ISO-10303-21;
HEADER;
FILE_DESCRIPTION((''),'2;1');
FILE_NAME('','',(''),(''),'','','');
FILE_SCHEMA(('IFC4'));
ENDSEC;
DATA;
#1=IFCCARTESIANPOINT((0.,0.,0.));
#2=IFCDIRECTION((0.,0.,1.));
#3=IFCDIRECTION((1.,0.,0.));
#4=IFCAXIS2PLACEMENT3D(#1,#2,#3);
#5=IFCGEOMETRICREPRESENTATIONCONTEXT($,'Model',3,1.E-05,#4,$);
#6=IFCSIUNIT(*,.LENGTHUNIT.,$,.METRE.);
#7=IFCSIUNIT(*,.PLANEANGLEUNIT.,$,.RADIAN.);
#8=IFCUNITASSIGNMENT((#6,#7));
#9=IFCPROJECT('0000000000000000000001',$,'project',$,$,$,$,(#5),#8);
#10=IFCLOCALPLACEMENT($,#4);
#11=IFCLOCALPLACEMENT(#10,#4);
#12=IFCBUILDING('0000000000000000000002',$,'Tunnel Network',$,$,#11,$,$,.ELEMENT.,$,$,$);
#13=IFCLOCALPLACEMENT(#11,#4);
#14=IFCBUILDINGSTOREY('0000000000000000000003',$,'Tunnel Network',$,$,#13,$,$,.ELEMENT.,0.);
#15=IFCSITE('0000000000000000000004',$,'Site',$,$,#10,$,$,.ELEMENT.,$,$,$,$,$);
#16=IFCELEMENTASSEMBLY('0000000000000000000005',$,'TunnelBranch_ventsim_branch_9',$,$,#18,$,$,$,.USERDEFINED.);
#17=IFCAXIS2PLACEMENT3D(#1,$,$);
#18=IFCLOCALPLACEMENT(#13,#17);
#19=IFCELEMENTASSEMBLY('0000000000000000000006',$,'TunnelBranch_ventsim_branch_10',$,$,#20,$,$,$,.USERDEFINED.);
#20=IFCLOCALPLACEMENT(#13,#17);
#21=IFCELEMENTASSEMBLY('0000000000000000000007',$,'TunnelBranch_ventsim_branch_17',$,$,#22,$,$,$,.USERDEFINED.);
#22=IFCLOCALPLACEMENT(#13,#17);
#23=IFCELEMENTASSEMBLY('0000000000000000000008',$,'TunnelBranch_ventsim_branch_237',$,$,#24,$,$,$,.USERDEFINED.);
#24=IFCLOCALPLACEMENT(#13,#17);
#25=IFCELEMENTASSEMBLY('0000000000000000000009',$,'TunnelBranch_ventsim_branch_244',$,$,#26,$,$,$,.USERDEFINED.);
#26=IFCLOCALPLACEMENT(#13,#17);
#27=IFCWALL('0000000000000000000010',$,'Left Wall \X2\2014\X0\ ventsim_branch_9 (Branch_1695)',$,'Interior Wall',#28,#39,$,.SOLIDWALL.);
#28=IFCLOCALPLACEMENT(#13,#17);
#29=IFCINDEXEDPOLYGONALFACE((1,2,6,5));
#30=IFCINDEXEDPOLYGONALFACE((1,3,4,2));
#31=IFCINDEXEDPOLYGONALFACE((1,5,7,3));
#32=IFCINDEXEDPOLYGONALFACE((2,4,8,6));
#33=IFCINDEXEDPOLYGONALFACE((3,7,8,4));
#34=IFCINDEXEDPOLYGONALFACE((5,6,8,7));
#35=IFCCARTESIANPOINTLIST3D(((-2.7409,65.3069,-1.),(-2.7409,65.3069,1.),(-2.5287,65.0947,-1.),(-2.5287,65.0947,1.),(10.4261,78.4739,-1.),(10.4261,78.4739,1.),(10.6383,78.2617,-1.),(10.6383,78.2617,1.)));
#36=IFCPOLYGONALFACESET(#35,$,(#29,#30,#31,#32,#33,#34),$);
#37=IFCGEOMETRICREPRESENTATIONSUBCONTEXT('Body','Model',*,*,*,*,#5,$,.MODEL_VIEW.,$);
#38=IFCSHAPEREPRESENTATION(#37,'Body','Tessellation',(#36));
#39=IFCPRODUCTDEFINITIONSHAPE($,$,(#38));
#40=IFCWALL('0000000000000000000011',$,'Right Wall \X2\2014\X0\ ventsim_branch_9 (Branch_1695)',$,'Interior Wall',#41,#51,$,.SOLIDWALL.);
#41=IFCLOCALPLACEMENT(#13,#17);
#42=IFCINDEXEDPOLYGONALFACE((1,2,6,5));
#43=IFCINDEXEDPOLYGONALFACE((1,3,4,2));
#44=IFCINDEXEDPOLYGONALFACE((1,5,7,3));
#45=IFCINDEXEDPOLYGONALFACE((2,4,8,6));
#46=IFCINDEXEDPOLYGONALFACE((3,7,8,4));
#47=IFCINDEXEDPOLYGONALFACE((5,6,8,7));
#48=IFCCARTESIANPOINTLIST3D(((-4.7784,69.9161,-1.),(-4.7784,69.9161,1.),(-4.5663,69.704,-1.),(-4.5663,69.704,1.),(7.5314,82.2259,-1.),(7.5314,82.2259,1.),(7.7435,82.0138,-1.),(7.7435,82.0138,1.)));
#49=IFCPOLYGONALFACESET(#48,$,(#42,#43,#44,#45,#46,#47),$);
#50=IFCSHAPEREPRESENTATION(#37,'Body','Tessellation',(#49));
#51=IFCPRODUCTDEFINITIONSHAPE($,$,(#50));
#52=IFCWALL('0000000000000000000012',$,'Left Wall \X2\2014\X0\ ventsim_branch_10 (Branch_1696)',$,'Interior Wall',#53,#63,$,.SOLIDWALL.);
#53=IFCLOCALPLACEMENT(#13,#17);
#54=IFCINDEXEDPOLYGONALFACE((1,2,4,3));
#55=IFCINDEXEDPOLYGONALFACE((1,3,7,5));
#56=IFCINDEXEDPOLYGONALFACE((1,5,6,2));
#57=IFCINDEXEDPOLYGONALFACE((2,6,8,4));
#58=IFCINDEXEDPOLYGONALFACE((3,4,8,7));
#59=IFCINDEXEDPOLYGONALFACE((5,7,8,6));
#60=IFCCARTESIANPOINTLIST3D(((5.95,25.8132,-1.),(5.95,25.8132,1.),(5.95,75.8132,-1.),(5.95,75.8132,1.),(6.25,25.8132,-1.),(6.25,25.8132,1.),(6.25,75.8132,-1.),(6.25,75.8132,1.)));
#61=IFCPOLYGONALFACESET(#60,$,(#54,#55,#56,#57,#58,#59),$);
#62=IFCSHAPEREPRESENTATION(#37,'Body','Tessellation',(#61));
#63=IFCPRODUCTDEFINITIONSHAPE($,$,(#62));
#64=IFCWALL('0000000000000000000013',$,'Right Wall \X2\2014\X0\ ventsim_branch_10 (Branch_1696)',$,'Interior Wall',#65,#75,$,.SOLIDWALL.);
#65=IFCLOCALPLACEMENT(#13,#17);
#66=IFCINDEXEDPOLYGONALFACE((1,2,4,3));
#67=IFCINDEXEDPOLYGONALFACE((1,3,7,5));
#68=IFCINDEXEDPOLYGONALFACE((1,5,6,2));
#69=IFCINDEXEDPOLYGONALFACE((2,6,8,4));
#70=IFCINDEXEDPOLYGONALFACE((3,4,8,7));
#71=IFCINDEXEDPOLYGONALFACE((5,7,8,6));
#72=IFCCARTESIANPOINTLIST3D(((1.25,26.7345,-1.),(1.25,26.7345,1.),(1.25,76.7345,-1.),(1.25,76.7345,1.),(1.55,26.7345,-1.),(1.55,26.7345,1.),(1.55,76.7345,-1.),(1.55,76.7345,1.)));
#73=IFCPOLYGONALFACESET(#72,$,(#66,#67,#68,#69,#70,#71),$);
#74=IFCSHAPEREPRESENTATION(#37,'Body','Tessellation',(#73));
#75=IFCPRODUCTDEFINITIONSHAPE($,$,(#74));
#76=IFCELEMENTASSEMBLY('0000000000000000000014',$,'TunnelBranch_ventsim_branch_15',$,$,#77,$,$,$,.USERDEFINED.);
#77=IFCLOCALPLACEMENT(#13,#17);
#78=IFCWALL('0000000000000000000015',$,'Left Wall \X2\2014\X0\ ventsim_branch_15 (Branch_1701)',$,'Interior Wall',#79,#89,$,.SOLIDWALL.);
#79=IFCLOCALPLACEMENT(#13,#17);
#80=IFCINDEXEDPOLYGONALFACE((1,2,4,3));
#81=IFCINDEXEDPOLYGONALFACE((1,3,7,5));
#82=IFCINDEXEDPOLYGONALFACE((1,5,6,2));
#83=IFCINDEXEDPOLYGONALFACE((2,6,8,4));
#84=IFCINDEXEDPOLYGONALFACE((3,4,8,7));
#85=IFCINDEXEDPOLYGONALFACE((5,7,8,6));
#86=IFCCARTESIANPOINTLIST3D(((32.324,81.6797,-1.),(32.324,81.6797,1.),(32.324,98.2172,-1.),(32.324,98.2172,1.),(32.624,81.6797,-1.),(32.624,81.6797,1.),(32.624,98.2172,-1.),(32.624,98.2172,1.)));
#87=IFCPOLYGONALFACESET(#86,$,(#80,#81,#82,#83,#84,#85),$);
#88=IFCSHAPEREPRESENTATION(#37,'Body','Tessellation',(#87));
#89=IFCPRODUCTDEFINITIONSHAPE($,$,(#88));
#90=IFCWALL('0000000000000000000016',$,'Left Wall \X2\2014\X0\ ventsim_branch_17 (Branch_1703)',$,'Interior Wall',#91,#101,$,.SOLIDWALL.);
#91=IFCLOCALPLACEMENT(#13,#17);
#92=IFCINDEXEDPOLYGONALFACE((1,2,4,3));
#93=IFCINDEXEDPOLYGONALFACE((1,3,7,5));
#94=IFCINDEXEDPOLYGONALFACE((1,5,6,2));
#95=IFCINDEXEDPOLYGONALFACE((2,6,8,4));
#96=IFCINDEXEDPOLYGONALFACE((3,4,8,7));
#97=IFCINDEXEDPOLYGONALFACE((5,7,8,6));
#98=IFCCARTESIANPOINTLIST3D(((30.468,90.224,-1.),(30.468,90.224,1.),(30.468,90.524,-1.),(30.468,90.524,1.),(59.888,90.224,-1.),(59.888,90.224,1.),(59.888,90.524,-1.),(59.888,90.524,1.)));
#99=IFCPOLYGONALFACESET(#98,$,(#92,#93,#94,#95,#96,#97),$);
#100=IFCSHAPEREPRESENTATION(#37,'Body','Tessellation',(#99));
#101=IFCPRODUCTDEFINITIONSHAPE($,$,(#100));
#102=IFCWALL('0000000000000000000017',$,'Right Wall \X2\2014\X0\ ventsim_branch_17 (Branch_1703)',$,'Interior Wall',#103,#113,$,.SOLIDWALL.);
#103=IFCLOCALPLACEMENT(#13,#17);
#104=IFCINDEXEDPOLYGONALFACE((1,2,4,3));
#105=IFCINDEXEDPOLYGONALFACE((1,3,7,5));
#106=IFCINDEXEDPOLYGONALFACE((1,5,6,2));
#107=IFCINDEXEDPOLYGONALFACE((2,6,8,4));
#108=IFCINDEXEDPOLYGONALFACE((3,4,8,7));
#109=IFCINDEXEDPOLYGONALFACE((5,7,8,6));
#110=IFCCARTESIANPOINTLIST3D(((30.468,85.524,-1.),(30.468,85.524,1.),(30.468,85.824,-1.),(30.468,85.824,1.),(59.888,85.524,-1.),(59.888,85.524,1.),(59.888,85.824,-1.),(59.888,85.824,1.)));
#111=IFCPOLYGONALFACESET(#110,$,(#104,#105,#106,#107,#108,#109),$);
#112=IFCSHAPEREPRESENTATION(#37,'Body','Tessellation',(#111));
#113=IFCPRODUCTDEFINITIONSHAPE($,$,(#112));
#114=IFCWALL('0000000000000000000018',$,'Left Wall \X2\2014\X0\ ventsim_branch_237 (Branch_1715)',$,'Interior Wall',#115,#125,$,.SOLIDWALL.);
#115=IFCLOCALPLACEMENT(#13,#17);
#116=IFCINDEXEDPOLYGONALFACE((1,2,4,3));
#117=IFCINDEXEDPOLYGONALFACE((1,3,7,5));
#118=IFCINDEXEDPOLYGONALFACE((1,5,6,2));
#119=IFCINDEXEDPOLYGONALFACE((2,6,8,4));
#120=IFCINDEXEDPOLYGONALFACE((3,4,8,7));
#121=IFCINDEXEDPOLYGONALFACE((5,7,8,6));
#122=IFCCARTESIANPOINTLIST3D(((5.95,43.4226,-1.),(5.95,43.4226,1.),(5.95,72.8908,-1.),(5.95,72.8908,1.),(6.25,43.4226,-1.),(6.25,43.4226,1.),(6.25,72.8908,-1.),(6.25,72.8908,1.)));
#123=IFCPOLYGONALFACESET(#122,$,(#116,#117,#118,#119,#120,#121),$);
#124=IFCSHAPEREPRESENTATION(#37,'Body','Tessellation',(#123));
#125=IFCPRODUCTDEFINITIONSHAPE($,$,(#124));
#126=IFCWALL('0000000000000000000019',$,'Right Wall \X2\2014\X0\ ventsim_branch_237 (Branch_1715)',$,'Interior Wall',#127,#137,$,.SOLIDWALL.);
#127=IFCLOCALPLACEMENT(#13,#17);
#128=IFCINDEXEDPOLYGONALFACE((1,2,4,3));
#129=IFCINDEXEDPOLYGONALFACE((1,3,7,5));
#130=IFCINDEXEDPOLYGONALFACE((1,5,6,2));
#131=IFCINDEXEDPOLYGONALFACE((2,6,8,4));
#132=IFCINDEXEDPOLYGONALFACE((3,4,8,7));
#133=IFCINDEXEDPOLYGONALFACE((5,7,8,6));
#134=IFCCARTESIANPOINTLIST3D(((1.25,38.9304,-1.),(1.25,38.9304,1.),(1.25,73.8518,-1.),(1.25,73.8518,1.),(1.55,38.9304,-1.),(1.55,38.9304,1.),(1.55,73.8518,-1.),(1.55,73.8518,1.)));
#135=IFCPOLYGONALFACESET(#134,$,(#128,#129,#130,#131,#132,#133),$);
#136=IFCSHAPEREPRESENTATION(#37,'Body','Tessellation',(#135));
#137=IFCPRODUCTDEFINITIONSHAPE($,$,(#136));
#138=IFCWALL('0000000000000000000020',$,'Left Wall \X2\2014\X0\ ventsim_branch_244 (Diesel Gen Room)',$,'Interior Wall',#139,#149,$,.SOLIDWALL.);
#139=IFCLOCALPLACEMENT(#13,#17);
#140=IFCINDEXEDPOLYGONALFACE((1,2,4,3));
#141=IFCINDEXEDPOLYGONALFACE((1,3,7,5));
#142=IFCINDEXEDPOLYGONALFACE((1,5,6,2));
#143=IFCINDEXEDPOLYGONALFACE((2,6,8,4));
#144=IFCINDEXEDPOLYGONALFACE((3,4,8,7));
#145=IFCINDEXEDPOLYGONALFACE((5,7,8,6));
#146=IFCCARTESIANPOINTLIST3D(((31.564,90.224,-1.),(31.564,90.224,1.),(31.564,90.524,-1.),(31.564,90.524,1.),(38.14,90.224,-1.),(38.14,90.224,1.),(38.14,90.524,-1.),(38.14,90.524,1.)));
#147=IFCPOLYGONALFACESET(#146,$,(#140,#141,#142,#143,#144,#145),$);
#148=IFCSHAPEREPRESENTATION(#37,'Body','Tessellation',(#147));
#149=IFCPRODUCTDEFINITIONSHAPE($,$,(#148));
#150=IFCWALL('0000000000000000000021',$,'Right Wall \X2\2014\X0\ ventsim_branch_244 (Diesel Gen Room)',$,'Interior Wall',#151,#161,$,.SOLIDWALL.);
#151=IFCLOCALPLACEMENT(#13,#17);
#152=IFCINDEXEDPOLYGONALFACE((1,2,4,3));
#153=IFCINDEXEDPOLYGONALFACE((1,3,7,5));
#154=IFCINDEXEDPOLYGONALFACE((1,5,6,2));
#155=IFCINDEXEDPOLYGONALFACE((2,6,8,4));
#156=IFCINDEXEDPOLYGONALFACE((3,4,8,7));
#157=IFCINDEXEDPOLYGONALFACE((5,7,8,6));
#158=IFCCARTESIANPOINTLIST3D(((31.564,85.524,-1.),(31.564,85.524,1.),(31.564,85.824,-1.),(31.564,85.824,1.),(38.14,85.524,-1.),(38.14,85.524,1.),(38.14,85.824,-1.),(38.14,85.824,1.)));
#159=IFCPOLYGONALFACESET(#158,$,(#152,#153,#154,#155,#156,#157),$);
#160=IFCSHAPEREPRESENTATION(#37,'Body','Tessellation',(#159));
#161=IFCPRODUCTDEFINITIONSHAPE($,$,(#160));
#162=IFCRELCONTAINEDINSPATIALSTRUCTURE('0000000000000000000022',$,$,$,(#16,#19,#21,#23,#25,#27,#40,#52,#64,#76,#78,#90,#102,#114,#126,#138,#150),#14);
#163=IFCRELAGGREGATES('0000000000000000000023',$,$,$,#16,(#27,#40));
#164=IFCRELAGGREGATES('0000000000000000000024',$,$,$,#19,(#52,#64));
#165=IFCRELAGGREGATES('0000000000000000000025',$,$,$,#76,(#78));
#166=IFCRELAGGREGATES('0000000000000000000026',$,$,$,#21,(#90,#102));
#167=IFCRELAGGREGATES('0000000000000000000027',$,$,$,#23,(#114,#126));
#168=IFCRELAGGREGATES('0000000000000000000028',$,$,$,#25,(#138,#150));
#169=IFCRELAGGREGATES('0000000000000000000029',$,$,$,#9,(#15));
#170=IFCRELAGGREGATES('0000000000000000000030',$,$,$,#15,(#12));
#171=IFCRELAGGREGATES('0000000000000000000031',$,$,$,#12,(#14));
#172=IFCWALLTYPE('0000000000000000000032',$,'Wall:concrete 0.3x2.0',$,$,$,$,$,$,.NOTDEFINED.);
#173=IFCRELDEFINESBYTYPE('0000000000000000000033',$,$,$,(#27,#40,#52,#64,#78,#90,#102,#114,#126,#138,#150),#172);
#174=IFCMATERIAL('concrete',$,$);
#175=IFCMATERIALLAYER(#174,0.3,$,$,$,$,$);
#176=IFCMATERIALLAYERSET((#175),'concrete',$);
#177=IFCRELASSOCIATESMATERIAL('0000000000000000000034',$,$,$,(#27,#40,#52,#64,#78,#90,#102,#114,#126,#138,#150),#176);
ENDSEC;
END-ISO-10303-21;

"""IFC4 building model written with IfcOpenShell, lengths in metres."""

from ifc_helpers import new_model, si_unit, frame, origin_with_axes, origin_2d_with_axis, place, context, subcontext, project, spatial, rectangle, extrude, material, layer, layer_set, layer_usage, type_object, element, aggregate, save


model = new_model("IFC4")

# Units and contexts
model_context = context("Model", 3, precision=1e-05, world=origin_with_axes())
body_context = subcontext(model_context, "Body", "Model", "MODEL_VIEW")
ifc_project = project(units=[si_unit("LENGTHUNIT", "METRE"), si_unit("PLANEANGLEUNIT", "RADIAN")], contexts=[model_context])

# Site, building, storey
site_placement = place(None, origin_with_axes())
site = spatial("IfcSite", under=ifc_project, at=site_placement, Name="Site", CompositionType="ELEMENT")
building_placement = place(site_placement, origin_with_axes())
building = spatial("IfcBuilding", under=site, at=building_placement, Name="Tunnel Network", CompositionType="ELEMENT")
storey_placement = place(building_placement, origin_with_axes())
storey = spatial("IfcBuildingStorey", under=building, at=storey_placement, Name="Tunnel Network", CompositionType="ELEMENT", Elevation=0.0)

# Element assemblies
assembly_1_placement = place(storey_placement, frame((10.5322, 78.3678, 0.0), z_axis=(-0.707107, -0.707106, 0.0), x_axis=(-0.707106, 0.707107, 0.0)))
assembly_1 = element("IfcElementAssembly", 1, at=assembly_1_placement, inside=storey, Name="TunnelBranch_ventsim_branch_9", PredefinedType="USERDEFINED")
ifc_material_1 = material(Name="concrete")
ifc_layer_1 = layer(ifc_material_1, 0.3)
ifc_layer_set_1 = layer_set([ifc_layer_1], Name="concrete")
assembly_2_placement = place(storey_placement, frame((6.1, 75.8132, 0.0), z_axis=(0.0, -1.0, 0.0), x_axis=(-1.0, 0.0, 0.0)))
assembly_2 = element("IfcElementAssembly", 2, at=assembly_2_placement, inside=storey, Name="TunnelBranch_ventsim_branch_10", PredefinedType="USERDEFINED")
assembly_3_placement = place(storey_placement, frame((30.468, 90.374, 0.0), z_axis=(1.0, 0.0, 0.0), x_axis=(0.0, -1.0, 0.0)))
assembly_3 = element("IfcElementAssembly", 3, at=assembly_3_placement, inside=storey, Name="TunnelBranch_ventsim_branch_17", PredefinedType="USERDEFINED")
assembly_4_placement = place(storey_placement, frame((6.1, 72.8908, 0.0), z_axis=(0.0, -1.0, 0.0), x_axis=(-1.0, 0.0, 0.0)))
assembly_4 = element("IfcElementAssembly", 4, at=assembly_4_placement, inside=storey, Name="TunnelBranch_ventsim_branch_237", PredefinedType="USERDEFINED")
assembly_5_placement = place(storey_placement, frame((31.564, 90.374, 0.0), z_axis=(1.0, 0.0, 0.0), x_axis=(0.0, -1.0, 0.0)))
assembly_5 = element("IfcElementAssembly", 5, at=assembly_5_placement, inside=storey, Name="TunnelBranch_ventsim_branch_244", PredefinedType="USERDEFINED")

# Walls
ifc_layer_usage_1 = layer_usage(ifc_layer_set_1, "AXIS2", "POSITIVE", 0.0)
wall_type_1 = type_object("IfcWallType", Name="Wall:concrete 0.3x2.0")
wall_1_placement = place(storey_placement, frame((10.5322, 78.3678, 0.0), z_axis=(-0.707107, -0.707106, 0.0), x_axis=(-0.707106, 0.707107, 0.0)))
wall_1 = element("IfcWall", 6, at=wall_1_placement, inside=storey, type_object=wall_type_1, material=ifc_layer_usage_1, Name="Left Wall — ventsim_branch_9 (Branch_1695)", ObjectType="Interior Wall", PredefinedType="SOLIDWALL", context=body_context, shape_type="SweptSolid", body=[
    extrude(rectangle(XDim=0.3, YDim=2.0, at=origin_2d_with_axis()), origin_with_axes(), (0.0, 0.0, 1.0), 18.621),
])
ifc_layer_usage_2 = layer_usage(ifc_layer_set_1, "AXIS2", "POSITIVE", 0.0)
wall_2_placement = place(storey_placement, frame((7.6374, 82.1198, 0.0), z_axis=(-0.707107, -0.707106, 0.0), x_axis=(-0.707106, 0.707107, 0.0)))
wall_2 = element("IfcWall", 7, at=wall_2_placement, inside=storey, type_object=wall_type_1, material=ifc_layer_usage_2, Name="Right Wall — ventsim_branch_9 (Branch_1695)", ObjectType="Interior Wall", PredefinedType="SOLIDWALL", context=body_context, shape_type="SweptSolid", body=[
    extrude(rectangle(XDim=0.3, YDim=2.0, at=origin_2d_with_axis()), origin_with_axes(), (0.0, 0.0, 1.0), 17.4086),
])
aggregate(assembly_1, [wall_1, wall_2])
ifc_layer_usage_3 = layer_usage(ifc_layer_set_1, "AXIS2", "POSITIVE", 0.0)
wall_3_placement = place(storey_placement, frame((6.1, 75.8132, 0.0), z_axis=(0.0, -1.0, 0.0), x_axis=(-1.0, 0.0, 0.0)))
wall_3 = element("IfcWall", 8, at=wall_3_placement, inside=storey, type_object=wall_type_1, material=ifc_layer_usage_3, Name="Left Wall — ventsim_branch_10 (Branch_1696)", ObjectType="Interior Wall", PredefinedType="SOLIDWALL", context=body_context, shape_type="SweptSolid", body=[
    extrude(rectangle(XDim=0.3, YDim=2.0, at=origin_2d_with_axis()), origin_with_axes(), (0.0, 0.0, 1.0), 50.0),
])
ifc_layer_usage_4 = layer_usage(ifc_layer_set_1, "AXIS2", "POSITIVE", 0.0)
wall_4_placement = place(storey_placement, frame((1.4, 76.7345, 0.0), z_axis=(0.0, -1.0, 0.0), x_axis=(-1.0, 0.0, 0.0)))
wall_4 = element("IfcWall", 9, at=wall_4_placement, inside=storey, type_object=wall_type_1, material=ifc_layer_usage_4, Name="Right Wall — ventsim_branch_10 (Branch_1696)", ObjectType="Interior Wall", PredefinedType="SOLIDWALL", context=body_context, shape_type="SweptSolid", body=[
    extrude(rectangle(XDim=0.3, YDim=2.0, at=origin_2d_with_axis()), origin_with_axes(), (0.0, 0.0, 1.0), 50.0),
])
aggregate(assembly_2, [wall_3, wall_4])

# Element assembly, wall
assembly_6_placement = place(storey_placement, frame((32.474, 81.6797, 0.0), z_axis=(0.0, 1.0, 0.0), x_axis=(1.0, 0.0, 0.0)))
assembly_6 = element("IfcElementAssembly", 10, at=assembly_6_placement, inside=storey, Name="TunnelBranch_ventsim_branch_15", PredefinedType="USERDEFINED")
ifc_layer_usage_5 = layer_usage(ifc_layer_set_1, "AXIS2", "POSITIVE", 0.0)
wall_5_placement = place(storey_placement, frame((32.474, 81.6797, 0.0), z_axis=(0.0, 1.0, 0.0), x_axis=(1.0, 0.0, 0.0)))
wall_5 = element("IfcWall", 11, at=wall_5_placement, inside=storey, type_object=wall_type_1, material=ifc_layer_usage_5, Name="Left Wall — ventsim_branch_15 (Branch_1701)", ObjectType="Interior Wall", PredefinedType="SOLIDWALL", context=body_context, shape_type="SweptSolid", body=[
    extrude(rectangle(XDim=0.3, YDim=2.0, at=origin_2d_with_axis()), origin_with_axes(), (0.0, 0.0, 1.0), 16.5375),
])
aggregate(assembly_6, [wall_5])

# Walls
ifc_layer_usage_6 = layer_usage(ifc_layer_set_1, "AXIS2", "POSITIVE", 0.0)
wall_6_placement = place(storey_placement, frame((30.468, 90.374, 0.0), z_axis=(1.0, 0.0, 0.0), x_axis=(0.0, -1.0, 0.0)))
wall_6 = element("IfcWall", 12, at=wall_6_placement, inside=storey, type_object=wall_type_1, material=ifc_layer_usage_6, Name="Left Wall — ventsim_branch_17 (Branch_1703)", ObjectType="Interior Wall", PredefinedType="SOLIDWALL", context=body_context, shape_type="SweptSolid", body=[
    extrude(rectangle(XDim=0.3, YDim=2.0, at=origin_2d_with_axis()), origin_with_axes(), (0.0, 0.0, 1.0), 29.42),
])
ifc_layer_usage_7 = layer_usage(ifc_layer_set_1, "AXIS2", "POSITIVE", 0.0)
wall_7_placement = place(storey_placement, frame((30.468, 85.674, 0.0), z_axis=(1.0, 0.0, 0.0), x_axis=(0.0, -1.0, 0.0)))
wall_7 = element("IfcWall", 13, at=wall_7_placement, inside=storey, type_object=wall_type_1, material=ifc_layer_usage_7, Name="Right Wall — ventsim_branch_17 (Branch_1703)", ObjectType="Interior Wall", PredefinedType="SOLIDWALL", context=body_context, shape_type="SweptSolid", body=[
    extrude(rectangle(XDim=0.3, YDim=2.0, at=origin_2d_with_axis()), origin_with_axes(), (0.0, 0.0, 1.0), 29.42),
])
aggregate(assembly_3, [wall_6, wall_7])
ifc_layer_usage_8 = layer_usage(ifc_layer_set_1, "AXIS2", "POSITIVE", 0.0)
wall_8_placement = place(storey_placement, frame((6.1, 72.8908, 0.0), z_axis=(0.0, -1.0, 0.0), x_axis=(-1.0, 0.0, 0.0)))
wall_8 = element("IfcWall", 14, at=wall_8_placement, inside=storey, type_object=wall_type_1, material=ifc_layer_usage_8, Name="Left Wall — ventsim_branch_237 (Branch_1715)", ObjectType="Interior Wall", PredefinedType="SOLIDWALL", context=body_context, shape_type="SweptSolid", body=[
    extrude(rectangle(XDim=0.3, YDim=2.0, at=origin_2d_with_axis()), origin_with_axes(), (0.0, 0.0, 1.0), 29.4681),
])
ifc_layer_usage_9 = layer_usage(ifc_layer_set_1, "AXIS2", "POSITIVE", 0.0)
wall_9_placement = place(storey_placement, frame((1.4, 73.8518, 0.0), z_axis=(0.0, -1.0, 0.0), x_axis=(-1.0, 0.0, 0.0)))
wall_9 = element("IfcWall", 15, at=wall_9_placement, inside=storey, type_object=wall_type_1, material=ifc_layer_usage_9, Name="Right Wall — ventsim_branch_237 (Branch_1715)", ObjectType="Interior Wall", PredefinedType="SOLIDWALL", context=body_context, shape_type="SweptSolid", body=[
    extrude(rectangle(XDim=0.3, YDim=2.0, at=origin_2d_with_axis()), origin_with_axes(), (0.0, 0.0, 1.0), 34.9214),
])
aggregate(assembly_4, [wall_8, wall_9])
ifc_layer_usage_10 = layer_usage(ifc_layer_set_1, "AXIS2", "POSITIVE", 0.0)
wall_10_placement = place(storey_placement, frame((31.564, 90.374, 0.0), z_axis=(1.0, 0.0, 0.0), x_axis=(0.0, -1.0, 0.0)))
wall_10 = element("IfcWall", 16, at=wall_10_placement, inside=storey, type_object=wall_type_1, material=ifc_layer_usage_10, Name="Left Wall — ventsim_branch_244 (Diesel Gen Room)", ObjectType="Interior Wall", PredefinedType="SOLIDWALL", context=body_context, shape_type="SweptSolid", body=[
    extrude(rectangle(XDim=0.3, YDim=2.0, at=origin_2d_with_axis()), origin_with_axes(), (0.0, 0.0, 1.0), 6.576),
])
ifc_layer_usage_11 = layer_usage(ifc_layer_set_1, "AXIS2", "POSITIVE", 0.0)
wall_11_placement = place(storey_placement, frame((31.564, 85.674, 0.0), z_axis=(1.0, 0.0, 0.0), x_axis=(0.0, -1.0, 0.0)))
wall_11 = element("IfcWall", 17, at=wall_11_placement, inside=storey, type_object=wall_type_1, material=ifc_layer_usage_11, Name="Right Wall — ventsim_branch_244 (Diesel Gen Room)", ObjectType="Interior Wall", PredefinedType="SOLIDWALL", context=body_context, shape_type="SweptSolid", body=[
    extrude(rectangle(XDim=0.3, YDim=2.0, at=origin_2d_with_axis()), origin_with_axes(), (0.0, 0.0, 1.0), 6.576),
])
aggregate(assembly_5, [wall_10, wall_11])

save(model, "model.ifc")
